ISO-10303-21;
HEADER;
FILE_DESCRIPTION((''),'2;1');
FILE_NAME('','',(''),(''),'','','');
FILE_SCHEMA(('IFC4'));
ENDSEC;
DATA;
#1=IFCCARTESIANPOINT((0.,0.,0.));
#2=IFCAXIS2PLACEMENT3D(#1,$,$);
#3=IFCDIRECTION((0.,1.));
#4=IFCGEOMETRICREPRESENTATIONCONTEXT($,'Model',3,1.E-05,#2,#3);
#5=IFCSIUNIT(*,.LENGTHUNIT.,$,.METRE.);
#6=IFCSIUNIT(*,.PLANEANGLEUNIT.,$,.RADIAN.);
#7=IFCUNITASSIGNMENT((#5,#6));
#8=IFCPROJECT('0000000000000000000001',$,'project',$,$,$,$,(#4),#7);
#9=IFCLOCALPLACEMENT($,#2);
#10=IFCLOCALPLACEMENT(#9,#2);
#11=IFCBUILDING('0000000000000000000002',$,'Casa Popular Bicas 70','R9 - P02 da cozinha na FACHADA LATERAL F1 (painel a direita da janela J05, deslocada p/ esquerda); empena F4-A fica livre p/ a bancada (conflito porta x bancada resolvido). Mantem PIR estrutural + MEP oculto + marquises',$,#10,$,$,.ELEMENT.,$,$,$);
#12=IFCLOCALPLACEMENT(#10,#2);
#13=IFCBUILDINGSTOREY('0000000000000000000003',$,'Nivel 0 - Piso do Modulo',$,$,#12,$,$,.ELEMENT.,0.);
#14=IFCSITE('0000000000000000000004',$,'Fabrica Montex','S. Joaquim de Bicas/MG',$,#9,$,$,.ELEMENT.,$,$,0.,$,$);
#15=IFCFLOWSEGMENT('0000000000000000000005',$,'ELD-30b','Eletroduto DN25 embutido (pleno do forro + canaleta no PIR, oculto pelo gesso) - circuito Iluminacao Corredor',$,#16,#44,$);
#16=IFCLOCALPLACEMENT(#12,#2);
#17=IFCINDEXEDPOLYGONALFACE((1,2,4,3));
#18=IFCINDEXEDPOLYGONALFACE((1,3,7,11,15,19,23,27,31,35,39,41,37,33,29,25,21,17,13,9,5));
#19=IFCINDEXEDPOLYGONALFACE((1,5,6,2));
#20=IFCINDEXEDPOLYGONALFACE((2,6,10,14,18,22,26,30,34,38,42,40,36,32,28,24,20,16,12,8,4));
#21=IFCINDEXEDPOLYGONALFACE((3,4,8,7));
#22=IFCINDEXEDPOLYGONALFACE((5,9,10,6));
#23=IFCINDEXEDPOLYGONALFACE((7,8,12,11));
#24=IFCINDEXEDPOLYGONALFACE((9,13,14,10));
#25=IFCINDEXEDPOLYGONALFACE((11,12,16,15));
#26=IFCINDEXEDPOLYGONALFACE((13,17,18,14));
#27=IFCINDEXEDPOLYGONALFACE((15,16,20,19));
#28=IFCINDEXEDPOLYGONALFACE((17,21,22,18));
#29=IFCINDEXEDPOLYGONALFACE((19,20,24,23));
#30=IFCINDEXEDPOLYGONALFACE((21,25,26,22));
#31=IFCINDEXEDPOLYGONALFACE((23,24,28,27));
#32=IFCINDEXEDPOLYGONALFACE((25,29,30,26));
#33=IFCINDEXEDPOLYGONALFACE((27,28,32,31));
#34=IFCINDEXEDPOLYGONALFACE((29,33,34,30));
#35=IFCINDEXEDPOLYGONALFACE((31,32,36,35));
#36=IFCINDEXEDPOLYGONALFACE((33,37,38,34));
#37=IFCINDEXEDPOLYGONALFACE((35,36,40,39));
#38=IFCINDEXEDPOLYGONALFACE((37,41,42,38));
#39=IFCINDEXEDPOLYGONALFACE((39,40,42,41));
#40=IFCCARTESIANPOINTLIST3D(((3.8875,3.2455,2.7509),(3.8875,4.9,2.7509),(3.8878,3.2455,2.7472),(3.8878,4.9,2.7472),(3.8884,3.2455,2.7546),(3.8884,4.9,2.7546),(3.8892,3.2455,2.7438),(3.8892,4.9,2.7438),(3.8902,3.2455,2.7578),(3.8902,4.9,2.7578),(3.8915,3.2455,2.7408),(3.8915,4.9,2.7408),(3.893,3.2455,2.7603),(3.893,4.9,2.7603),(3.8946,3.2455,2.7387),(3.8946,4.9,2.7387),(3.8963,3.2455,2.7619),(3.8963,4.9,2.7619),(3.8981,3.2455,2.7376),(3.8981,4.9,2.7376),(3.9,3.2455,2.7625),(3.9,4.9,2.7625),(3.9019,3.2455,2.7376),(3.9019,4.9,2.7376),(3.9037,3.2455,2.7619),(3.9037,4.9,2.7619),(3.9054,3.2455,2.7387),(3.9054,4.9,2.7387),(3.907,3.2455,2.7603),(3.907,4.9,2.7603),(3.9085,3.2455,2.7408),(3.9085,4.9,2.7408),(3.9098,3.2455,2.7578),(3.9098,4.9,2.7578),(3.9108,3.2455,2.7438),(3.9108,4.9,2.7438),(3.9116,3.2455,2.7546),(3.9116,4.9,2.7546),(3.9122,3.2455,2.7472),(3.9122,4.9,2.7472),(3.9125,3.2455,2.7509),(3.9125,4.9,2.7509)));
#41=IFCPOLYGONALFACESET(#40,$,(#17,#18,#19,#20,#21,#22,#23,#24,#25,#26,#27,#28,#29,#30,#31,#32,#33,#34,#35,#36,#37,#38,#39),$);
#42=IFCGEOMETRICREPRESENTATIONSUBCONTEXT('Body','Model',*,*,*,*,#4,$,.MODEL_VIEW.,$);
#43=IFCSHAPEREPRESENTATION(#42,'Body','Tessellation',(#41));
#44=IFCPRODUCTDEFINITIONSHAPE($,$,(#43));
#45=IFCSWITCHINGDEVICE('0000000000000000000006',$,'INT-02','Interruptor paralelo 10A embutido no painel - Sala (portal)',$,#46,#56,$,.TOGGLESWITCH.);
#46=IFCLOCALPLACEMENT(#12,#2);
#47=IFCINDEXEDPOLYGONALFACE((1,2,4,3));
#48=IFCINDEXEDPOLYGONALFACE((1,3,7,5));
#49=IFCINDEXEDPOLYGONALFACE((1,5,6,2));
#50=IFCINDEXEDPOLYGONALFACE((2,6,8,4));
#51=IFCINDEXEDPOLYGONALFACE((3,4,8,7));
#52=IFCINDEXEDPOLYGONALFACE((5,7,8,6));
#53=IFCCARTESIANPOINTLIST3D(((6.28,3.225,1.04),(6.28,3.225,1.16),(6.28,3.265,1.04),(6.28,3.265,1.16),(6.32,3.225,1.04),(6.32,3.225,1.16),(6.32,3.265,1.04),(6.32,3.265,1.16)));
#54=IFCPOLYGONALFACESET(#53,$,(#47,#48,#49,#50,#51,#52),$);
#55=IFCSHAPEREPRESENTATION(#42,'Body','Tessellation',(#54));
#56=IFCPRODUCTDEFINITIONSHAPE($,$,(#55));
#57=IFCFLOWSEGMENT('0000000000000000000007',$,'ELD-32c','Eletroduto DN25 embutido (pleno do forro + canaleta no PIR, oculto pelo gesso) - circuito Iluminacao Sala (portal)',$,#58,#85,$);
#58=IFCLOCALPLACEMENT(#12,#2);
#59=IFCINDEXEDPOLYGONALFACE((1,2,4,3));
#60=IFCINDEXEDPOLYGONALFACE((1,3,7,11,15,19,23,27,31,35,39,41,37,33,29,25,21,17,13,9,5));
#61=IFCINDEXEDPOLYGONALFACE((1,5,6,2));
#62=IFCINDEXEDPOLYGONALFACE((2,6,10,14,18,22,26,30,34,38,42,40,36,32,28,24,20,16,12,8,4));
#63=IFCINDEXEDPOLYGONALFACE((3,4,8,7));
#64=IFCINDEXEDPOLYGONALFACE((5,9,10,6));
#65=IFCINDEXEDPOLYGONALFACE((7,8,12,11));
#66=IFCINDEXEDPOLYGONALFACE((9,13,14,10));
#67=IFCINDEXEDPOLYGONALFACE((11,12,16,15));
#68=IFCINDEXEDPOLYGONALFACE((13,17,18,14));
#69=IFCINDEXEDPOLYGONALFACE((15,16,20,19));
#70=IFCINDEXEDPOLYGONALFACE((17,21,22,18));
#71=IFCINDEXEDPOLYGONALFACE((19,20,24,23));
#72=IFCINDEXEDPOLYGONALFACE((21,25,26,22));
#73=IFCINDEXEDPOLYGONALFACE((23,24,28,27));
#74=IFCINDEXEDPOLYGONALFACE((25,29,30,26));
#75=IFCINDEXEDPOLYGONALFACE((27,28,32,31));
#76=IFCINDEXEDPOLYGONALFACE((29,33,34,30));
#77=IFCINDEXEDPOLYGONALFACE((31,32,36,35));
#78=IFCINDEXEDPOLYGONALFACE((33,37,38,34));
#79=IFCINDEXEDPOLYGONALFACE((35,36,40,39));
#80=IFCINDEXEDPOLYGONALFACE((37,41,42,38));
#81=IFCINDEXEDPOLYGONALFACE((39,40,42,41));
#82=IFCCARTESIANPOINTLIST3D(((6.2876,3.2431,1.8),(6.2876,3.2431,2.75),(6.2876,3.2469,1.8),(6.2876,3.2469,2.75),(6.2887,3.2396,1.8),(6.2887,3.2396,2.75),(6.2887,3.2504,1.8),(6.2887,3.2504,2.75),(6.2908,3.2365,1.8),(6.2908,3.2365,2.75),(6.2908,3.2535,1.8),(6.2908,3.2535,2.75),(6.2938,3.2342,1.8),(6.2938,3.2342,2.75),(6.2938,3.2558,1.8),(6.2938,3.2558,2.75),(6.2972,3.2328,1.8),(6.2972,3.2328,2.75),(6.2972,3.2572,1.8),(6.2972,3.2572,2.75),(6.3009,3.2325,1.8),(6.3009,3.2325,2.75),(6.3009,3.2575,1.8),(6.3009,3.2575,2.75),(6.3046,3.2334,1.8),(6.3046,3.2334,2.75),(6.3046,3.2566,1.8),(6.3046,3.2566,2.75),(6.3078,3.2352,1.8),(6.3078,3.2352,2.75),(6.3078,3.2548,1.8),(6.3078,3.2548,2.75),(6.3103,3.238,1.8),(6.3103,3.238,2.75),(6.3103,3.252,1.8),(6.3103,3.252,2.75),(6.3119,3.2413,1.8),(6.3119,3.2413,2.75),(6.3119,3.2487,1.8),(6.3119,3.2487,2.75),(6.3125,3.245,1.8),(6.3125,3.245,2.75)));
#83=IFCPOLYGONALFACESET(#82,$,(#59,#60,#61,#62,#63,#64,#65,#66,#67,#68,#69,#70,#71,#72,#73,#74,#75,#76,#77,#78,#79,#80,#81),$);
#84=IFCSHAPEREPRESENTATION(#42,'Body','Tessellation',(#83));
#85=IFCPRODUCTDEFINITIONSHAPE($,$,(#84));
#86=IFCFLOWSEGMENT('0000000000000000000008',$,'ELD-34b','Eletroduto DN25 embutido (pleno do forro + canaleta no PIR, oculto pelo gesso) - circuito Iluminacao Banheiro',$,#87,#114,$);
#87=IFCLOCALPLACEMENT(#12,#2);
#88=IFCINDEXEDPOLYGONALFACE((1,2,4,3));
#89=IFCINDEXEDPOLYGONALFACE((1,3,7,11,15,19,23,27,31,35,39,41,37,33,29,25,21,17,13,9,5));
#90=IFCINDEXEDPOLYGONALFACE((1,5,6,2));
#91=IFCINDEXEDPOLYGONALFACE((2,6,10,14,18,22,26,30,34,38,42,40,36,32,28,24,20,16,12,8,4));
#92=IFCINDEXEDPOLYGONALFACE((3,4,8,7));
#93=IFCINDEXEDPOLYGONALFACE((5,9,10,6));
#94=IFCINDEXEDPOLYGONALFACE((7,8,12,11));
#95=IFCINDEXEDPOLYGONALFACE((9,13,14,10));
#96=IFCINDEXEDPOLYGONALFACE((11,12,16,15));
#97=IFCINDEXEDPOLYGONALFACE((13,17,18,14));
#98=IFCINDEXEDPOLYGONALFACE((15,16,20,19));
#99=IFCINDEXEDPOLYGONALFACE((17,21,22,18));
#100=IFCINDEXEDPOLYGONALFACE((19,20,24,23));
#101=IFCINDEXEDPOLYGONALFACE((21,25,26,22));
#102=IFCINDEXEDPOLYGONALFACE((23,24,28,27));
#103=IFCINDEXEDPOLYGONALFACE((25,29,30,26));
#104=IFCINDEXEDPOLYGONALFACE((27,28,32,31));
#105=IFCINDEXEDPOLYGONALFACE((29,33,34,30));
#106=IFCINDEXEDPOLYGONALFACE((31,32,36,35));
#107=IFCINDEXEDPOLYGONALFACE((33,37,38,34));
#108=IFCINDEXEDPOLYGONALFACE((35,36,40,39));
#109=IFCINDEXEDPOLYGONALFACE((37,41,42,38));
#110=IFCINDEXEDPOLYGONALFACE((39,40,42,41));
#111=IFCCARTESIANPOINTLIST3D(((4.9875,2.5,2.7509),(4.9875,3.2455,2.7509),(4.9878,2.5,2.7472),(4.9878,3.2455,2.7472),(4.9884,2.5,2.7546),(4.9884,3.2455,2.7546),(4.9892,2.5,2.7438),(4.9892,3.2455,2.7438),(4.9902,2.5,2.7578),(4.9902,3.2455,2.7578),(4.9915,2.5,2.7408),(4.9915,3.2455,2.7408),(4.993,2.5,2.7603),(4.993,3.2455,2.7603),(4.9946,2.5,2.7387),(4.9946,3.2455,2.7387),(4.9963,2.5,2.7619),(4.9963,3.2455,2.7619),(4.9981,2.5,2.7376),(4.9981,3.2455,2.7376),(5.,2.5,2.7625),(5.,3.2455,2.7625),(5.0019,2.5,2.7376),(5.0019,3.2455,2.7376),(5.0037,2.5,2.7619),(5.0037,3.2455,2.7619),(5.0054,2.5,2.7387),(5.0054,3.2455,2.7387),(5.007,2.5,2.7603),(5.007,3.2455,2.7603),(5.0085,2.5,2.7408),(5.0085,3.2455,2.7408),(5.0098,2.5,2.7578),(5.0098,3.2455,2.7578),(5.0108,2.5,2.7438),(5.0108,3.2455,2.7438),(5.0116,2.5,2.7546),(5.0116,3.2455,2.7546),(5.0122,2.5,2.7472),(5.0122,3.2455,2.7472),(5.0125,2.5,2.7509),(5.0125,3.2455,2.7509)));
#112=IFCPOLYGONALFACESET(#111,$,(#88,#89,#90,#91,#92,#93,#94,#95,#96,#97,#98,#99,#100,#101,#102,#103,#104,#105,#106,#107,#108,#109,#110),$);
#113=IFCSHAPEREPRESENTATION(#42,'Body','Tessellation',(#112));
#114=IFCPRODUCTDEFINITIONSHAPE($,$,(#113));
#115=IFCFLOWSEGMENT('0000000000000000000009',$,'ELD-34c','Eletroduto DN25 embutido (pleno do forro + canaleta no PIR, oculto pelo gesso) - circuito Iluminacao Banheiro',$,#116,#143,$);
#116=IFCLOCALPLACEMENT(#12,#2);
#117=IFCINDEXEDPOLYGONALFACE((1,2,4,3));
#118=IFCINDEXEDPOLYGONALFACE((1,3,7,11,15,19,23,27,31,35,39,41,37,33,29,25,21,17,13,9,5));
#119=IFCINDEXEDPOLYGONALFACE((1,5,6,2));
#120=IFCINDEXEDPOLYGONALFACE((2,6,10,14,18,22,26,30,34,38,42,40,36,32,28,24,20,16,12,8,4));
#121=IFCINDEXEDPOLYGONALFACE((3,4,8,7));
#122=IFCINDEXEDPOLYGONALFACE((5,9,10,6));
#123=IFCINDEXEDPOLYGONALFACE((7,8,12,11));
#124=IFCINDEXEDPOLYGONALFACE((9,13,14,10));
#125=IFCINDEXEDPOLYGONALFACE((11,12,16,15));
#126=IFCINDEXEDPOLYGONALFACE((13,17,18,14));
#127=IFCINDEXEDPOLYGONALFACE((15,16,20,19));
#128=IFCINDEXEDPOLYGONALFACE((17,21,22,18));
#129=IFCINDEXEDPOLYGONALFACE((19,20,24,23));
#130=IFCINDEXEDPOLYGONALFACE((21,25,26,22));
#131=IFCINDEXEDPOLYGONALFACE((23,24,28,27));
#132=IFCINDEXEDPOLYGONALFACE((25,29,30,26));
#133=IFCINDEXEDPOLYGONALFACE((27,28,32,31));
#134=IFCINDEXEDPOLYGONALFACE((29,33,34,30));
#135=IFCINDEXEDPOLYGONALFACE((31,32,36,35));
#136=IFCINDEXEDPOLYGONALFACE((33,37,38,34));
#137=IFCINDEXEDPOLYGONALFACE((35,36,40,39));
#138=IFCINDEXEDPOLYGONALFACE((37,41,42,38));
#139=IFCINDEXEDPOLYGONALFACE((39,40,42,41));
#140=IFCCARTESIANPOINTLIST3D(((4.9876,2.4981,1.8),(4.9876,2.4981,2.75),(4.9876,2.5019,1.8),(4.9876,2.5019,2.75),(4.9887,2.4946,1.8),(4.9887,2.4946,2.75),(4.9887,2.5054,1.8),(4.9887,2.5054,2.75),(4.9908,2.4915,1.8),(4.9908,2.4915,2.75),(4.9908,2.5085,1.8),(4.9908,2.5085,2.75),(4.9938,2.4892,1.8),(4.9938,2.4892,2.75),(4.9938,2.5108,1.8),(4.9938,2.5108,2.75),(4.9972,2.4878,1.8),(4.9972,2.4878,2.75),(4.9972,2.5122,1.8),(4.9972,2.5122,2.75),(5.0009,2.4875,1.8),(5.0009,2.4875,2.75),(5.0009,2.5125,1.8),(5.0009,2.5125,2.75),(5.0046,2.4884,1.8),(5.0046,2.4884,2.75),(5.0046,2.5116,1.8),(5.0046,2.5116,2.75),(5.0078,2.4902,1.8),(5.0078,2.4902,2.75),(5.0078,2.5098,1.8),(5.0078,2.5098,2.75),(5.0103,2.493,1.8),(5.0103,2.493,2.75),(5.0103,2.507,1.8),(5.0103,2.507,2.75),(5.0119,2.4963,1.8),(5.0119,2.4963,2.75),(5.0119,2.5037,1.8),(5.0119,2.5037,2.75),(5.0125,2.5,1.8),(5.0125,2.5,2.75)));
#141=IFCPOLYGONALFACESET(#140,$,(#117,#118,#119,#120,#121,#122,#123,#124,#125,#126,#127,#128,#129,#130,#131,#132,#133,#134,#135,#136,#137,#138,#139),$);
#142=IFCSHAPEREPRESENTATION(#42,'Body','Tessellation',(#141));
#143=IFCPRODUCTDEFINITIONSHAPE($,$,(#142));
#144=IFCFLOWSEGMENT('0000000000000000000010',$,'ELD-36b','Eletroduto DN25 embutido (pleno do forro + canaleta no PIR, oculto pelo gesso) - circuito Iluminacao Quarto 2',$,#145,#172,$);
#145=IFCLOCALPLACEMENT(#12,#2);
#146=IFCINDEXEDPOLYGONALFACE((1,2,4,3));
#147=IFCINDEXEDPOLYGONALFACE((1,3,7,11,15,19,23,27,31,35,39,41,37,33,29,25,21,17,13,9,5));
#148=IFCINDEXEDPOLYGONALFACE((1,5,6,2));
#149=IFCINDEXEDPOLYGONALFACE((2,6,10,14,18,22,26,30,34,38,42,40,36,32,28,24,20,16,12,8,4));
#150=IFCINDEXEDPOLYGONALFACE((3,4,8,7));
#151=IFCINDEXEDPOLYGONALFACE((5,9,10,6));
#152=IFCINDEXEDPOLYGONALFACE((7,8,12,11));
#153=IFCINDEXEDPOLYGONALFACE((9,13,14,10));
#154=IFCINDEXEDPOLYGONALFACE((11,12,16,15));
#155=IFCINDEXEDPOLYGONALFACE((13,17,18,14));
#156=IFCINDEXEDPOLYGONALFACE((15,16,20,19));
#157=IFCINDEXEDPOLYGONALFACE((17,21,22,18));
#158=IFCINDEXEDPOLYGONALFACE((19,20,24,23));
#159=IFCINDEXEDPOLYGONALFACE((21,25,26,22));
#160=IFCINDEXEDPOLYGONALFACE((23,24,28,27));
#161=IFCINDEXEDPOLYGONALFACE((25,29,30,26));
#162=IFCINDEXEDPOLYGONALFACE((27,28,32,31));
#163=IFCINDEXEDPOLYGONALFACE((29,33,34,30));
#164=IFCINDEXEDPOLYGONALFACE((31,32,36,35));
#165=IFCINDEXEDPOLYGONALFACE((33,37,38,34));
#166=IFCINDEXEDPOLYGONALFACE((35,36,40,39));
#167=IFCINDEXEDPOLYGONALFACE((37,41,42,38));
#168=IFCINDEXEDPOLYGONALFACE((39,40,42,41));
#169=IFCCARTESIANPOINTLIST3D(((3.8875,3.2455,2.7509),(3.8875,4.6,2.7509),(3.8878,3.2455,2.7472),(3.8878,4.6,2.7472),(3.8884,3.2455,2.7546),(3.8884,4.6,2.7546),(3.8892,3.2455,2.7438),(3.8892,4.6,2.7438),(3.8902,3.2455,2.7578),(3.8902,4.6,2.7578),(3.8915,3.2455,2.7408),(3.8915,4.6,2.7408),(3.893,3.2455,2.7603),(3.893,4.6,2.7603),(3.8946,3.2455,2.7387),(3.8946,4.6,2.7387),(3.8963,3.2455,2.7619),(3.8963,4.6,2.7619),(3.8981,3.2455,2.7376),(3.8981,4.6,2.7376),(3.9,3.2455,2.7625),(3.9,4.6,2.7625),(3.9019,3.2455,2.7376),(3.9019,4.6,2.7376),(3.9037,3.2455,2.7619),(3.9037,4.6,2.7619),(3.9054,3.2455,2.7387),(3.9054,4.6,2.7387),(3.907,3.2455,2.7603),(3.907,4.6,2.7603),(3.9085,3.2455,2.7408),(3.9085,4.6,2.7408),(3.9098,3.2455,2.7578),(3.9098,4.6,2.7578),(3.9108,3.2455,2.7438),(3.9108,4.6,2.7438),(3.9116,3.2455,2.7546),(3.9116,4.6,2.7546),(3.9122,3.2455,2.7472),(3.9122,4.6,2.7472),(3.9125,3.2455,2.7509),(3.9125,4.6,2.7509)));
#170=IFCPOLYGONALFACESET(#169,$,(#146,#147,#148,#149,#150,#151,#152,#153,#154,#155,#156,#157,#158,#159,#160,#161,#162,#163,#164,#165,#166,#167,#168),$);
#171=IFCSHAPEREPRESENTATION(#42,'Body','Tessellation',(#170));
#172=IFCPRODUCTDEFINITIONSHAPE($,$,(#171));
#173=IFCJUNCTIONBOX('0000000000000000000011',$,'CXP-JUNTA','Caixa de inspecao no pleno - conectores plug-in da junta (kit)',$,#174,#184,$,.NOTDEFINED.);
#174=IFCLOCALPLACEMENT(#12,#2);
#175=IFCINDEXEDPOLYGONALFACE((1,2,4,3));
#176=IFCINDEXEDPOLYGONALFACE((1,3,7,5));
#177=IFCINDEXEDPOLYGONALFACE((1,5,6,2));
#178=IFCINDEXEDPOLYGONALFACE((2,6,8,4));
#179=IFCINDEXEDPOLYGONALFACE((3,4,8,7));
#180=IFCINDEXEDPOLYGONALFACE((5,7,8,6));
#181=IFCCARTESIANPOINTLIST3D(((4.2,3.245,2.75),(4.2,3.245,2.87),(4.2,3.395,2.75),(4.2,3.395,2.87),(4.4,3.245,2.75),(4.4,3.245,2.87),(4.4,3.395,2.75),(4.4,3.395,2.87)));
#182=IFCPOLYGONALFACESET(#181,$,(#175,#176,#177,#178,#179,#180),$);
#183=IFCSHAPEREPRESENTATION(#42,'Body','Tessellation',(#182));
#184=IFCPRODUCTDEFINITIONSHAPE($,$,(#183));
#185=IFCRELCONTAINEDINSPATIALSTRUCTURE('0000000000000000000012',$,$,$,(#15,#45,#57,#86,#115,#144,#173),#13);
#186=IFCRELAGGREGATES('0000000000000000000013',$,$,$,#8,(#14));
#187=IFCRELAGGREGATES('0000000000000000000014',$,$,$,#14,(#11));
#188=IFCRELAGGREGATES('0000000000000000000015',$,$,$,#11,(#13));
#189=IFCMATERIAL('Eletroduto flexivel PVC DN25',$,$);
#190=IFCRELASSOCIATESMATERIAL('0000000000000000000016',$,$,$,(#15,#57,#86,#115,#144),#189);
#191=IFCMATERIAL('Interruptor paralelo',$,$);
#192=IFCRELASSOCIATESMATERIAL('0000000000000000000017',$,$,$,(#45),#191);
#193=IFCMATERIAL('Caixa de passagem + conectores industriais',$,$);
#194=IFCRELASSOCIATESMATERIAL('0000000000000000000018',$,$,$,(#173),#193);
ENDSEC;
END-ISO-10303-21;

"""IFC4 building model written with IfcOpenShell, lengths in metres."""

from ifc_helpers import new_model, si_unit, direction, frame, frame_2d, origin, origin_2d, place, context, subcontext, project, spatial, rectangle, circle, extrude, material, element, save


model = new_model("IFC4")

# Units and contexts
model_context = context("Model", 3, precision=1e-05, world=origin(), true_north=direction((0.0, 1.0)))
body_context = subcontext(model_context, "Body", "Model", "MODEL_VIEW")
ifc_project = project(units=[si_unit("LENGTHUNIT", "METRE"), si_unit("PLANEANGLEUNIT", "RADIAN")], contexts=[model_context])

# Site, building, storey
site_placement = place(None, origin())
site = spatial("IfcSite", under=ifc_project, at=site_placement, Name="Fabrica Montex", Description="S. Joaquim de Bicas/MG", CompositionType="ELEMENT", RefElevation=0.0)
building_placement = place(site_placement, origin())
building = spatial("IfcBuilding", under=site, at=building_placement, Name="Casa Popular Bicas 70", Description="R9 - P02 da cozinha na FACHADA LATERAL F1 (painel a direita da janela J05, deslocada p/ esquerda); empena F4-A fica livre p/ a bancada (conflito porta x bancada resolvido). Mantem PIR estrutural + MEP oculto + marquises", CompositionType="ELEMENT")
storey_placement = place(building_placement, origin())
storey = spatial("IfcBuildingStorey", under=building, at=storey_placement, Name="Nivel 0 - Piso do Modulo", CompositionType="ELEMENT", Elevation=0.0)

# Shared definitions
ifc_material_1 = material(Name="Eletroduto flexivel PVC DN25")

# Flow segment
flow_segment_1_placement = place(storey_placement, frame((3.9, 3.2455, 2.75), z_axis=(0.0, 1.0, 0.0), x_axis=(0.0, 0.0, 1.0)))
element("IfcFlowSegment", 1, at=flow_segment_1_placement, inside=storey, material=ifc_material_1, Name="ELD-30b", Description="Eletroduto DN25 embutido (pleno do forro + canaleta no PIR, oculto pelo gesso) - circuito Iluminacao Corredor", context=body_context, shape_type="SweptSolid", body=[
    extrude(circle(Radius=0.0125, at=origin_2d()), origin(), (0.0, 0.0, 1.0), 1.6545),
])

# Switching device
ifc_material_2 = material(Name="Interruptor paralelo")
switching_device_placement = place(storey_placement, frame((6.28, 3.225, 1.04)))
element("IfcSwitchingDevice", 2, at=switching_device_placement, inside=storey, material=ifc_material_2, Name="INT-02", Description="Interruptor paralelo 10A embutido no painel - Sala (portal)", PredefinedType="TOGGLESWITCH", context=body_context, shape_type="SweptSolid", body=[
    extrude(rectangle(XDim=0.04, YDim=0.04, at=frame_2d((0.02, 0.02))), origin(), (0.0, 0.0, 1.0), 0.12),
])

# Flow segments
flow_segment_2_placement = place(storey_placement, frame((6.3, 3.245, 2.75), z_axis=(0.0, 0.0, -1.0), x_axis=(1.0, 0.0, 0.0)))
element("IfcFlowSegment", 3, at=flow_segment_2_placement, inside=storey, material=ifc_material_1, Name="ELD-32c", Description="Eletroduto DN25 embutido (pleno do forro + canaleta no PIR, oculto pelo gesso) - circuito Iluminacao Sala (portal)", context=body_context, shape_type="SweptSolid", body=[
    extrude(circle(Radius=0.0125, at=origin_2d()), origin(), (0.0, 0.0, 1.0), 0.95),
])
flow_segment_3_placement = place(storey_placement, frame((5.0, 3.2455, 2.75), z_axis=(0.0, -1.0, 0.0), x_axis=(0.0, 0.0, 1.0)))
element("IfcFlowSegment", 4, at=flow_segment_3_placement, inside=storey, material=ifc_material_1, Name="ELD-34b", Description="Eletroduto DN25 embutido (pleno do forro + canaleta no PIR, oculto pelo gesso) - circuito Iluminacao Banheiro", context=body_context, shape_type="SweptSolid", body=[
    extrude(circle(Radius=0.0125, at=origin_2d()), origin(), (0.0, 0.0, 1.0), 0.7455),
])
flow_segment_4_placement = place(storey_placement, frame((5.0, 2.5, 2.75), z_axis=(0.0, 0.0, -1.0), x_axis=(1.0, 0.0, 0.0)))
element("IfcFlowSegment", 5, at=flow_segment_4_placement, inside=storey, material=ifc_material_1, Name="ELD-34c", Description="Eletroduto DN25 embutido (pleno do forro + canaleta no PIR, oculto pelo gesso) - circuito Iluminacao Banheiro", context=body_context, shape_type="SweptSolid", body=[
    extrude(circle(Radius=0.0125, at=origin_2d()), origin(), (0.0, 0.0, 1.0), 0.95),
])
flow_segment_5_placement = place(storey_placement, frame((3.9, 3.2455, 2.75), z_axis=(0.0, 1.0, 0.0), x_axis=(0.0, 0.0, 1.0)))
element("IfcFlowSegment", 6, at=flow_segment_5_placement, inside=storey, material=ifc_material_1, Name="ELD-36b", Description="Eletroduto DN25 embutido (pleno do forro + canaleta no PIR, oculto pelo gesso) - circuito Iluminacao Quarto 2", context=body_context, shape_type="SweptSolid", body=[
    extrude(circle(Radius=0.0125, at=origin_2d()), origin(), (0.0, 0.0, 1.0), 1.3545),
])

# Junction box
ifc_material_3 = material(Name="Caixa de passagem + conectores industriais")
junction_box_placement = place(storey_placement, frame((4.2, 3.245, 2.75)))
element("IfcJunctionBox", 7, at=junction_box_placement, inside=storey, material=ifc_material_3, Name="CXP-JUNTA", Description="Caixa de inspecao no pleno - conectores plug-in da junta (kit)", PredefinedType="NOTDEFINED", context=body_context, shape_type="SweptSolid", body=[
    extrude(rectangle(XDim=0.2, YDim=0.15, at=frame_2d((0.1, 0.075))), origin(), (0.0, 0.0, 1.0), 0.12),
])

save(model, "model.ifc")
